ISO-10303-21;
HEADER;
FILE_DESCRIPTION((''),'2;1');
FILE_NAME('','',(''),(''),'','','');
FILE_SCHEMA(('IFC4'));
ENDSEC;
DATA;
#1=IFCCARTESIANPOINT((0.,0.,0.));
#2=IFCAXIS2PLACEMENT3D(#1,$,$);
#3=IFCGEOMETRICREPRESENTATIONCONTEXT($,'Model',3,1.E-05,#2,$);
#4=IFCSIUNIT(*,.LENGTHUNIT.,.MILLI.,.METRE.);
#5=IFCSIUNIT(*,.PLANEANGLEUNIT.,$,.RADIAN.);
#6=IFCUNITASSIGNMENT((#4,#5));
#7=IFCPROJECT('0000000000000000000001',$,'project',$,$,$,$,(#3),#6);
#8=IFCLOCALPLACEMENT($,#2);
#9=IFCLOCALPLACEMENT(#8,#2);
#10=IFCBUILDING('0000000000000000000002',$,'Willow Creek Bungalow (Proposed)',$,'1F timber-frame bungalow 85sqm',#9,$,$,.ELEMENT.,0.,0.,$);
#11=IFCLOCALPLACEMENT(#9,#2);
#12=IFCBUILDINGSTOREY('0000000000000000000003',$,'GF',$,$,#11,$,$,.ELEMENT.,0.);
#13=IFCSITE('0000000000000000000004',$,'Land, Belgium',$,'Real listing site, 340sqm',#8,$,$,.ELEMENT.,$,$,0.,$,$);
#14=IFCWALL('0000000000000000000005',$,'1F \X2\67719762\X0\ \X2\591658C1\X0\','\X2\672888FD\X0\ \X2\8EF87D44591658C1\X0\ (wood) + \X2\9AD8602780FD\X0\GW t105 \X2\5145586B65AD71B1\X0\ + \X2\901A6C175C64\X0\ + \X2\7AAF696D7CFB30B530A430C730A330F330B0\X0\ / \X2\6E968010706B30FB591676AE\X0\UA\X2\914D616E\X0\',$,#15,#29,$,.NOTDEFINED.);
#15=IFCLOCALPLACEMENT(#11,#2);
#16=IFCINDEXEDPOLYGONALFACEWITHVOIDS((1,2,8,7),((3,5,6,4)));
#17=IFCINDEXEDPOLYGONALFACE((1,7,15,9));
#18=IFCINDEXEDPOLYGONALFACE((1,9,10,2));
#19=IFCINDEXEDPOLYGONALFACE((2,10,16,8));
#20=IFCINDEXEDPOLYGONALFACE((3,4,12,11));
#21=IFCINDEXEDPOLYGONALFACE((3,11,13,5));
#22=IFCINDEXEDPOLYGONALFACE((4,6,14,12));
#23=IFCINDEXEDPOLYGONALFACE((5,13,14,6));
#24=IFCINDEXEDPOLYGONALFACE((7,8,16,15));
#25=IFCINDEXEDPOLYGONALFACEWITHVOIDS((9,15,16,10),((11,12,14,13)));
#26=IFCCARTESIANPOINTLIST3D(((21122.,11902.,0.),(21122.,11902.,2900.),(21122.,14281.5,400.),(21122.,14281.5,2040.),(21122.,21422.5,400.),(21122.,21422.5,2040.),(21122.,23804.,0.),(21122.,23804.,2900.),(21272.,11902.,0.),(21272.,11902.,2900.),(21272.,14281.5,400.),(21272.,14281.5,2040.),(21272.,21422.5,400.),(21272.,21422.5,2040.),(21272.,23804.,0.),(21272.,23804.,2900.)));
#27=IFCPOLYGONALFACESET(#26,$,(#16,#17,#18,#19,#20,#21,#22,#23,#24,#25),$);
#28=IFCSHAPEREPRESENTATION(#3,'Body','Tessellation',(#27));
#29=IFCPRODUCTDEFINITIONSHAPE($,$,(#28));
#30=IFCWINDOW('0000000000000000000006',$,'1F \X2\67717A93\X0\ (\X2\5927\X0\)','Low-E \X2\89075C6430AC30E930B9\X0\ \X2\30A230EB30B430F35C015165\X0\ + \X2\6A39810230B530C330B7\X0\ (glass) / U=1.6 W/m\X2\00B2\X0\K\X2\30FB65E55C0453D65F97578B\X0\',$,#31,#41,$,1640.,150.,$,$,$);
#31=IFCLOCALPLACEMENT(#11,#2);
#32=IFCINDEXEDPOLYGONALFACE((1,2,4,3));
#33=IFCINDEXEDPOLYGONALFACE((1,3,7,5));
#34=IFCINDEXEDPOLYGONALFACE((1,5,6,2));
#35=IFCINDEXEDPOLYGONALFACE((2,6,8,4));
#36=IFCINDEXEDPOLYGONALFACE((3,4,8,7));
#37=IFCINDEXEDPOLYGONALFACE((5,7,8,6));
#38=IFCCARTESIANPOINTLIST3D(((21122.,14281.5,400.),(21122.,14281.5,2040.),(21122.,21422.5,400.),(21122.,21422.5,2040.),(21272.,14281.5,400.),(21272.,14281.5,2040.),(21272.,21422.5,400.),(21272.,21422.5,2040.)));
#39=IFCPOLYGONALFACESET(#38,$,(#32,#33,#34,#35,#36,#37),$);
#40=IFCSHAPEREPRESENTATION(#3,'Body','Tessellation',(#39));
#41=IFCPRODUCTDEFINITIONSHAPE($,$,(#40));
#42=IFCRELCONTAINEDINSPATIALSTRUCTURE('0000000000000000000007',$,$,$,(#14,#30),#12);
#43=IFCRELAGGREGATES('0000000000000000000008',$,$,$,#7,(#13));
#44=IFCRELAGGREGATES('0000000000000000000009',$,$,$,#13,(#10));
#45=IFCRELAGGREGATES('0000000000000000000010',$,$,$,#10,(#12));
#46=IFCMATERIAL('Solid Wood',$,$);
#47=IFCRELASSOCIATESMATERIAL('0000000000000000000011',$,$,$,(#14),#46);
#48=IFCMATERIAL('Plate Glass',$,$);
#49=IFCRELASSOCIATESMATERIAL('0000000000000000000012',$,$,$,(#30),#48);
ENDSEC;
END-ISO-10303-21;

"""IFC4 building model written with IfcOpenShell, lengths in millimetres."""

from ifc_helpers import new_model, si_unit, frame, frame_2d, origin, place, context, project, spatial, rectangle, extrude, material, element, fill, save


model = new_model("IFC4")

# Units and contexts
model_context = context("Model", 3, precision=1e-05, world=origin())
ifc_project = project(units=[si_unit("LENGTHUNIT", "METRE", prefix="MILLI"), si_unit("PLANEANGLEUNIT", "RADIAN")], contexts=[model_context])

# Site, building, storey
site_placement = place(None, origin())
site = spatial("IfcSite", under=ifc_project, at=site_placement, Name="Land, Belgium", ObjectType="Real listing site, 340sqm", CompositionType="ELEMENT", RefElevation=0.0)
building_placement = place(site_placement, origin())
building = spatial("IfcBuilding", under=site, at=building_placement, Name="Willow Creek Bungalow (Proposed)", ObjectType="1F timber-frame bungalow 85sqm", CompositionType="ELEMENT", ElevationOfRefHeight=0.0, ElevationOfTerrain=0.0)
storey_placement = place(building_placement, origin())
storey = spatial("IfcBuildingStorey", under=building, at=storey_placement, Name="GF", CompositionType="ELEMENT", Elevation=0.0)

# Shared definitions
ifc_material_1 = material(Name="Solid Wood")

# Shared definitions
ifc_material_2 = material(Name="Plate Glass")

# Wall, opening, window
wall_1_placement = place(storey_placement, frame((10561.0, 5951.0, 0.0)))
wall_1 = element("IfcWall", 1, at=wall_1_placement, inside=storey, material=ifc_material_1, Name="1F 東面 外壁", Description="木製 軸組外壁 (wood) + 高性能GW t105 充填断熱 + 通気層 + 窯業系サイディング / 準耐火・外皮UA配慮", PredefinedType="NOTDEFINED", context=model_context, shape_type="SweptSolid", body=[
    extrude(rectangle(XDim=150.0, YDim=11902.0, at=frame_2d((75.0, 5951.0))), frame((10561.0, 5951.0, 0.0)), (0.0, 0.0, 1.0), 2900.0),
])
opening_1_placement = place(storey_placement, frame((10561.0, 7141.0, 200.0)))
opening_1 = element("IfcOpeningElement", 2, at=opening_1_placement, cuts=wall_1, PredefinedType="NOTDEFINED", context=model_context, shape_type="SweptSolid", body=[
    extrude(rectangle(XDim=150.0, YDim=7141.0, at=frame_2d((75.0, 3570.0))), frame((10561.0, 7141.0, 200.0)), (0.0, 0.0, 1.0), 1640.0),
])
window_1_placement = place(storey_placement, frame((10561.0, 7141.0, 200.0)))
window_1 = element("IfcWindow", 3, at=window_1_placement, inside=storey, material=ifc_material_2, Name="1F 東窓 (大)", Description="Low-E 複層ガラス アルゴン封入 + 樹脂サッシ (glass) / U=1.6 W/m²K・日射取得型", OverallHeight=1640.0, OverallWidth=150.0, context=model_context, shape_type="SweptSolid", body=[
    extrude(rectangle(XDim=150.0, YDim=7141.0, at=frame_2d((75.0, 3570.0))), frame((10561.0, 7141.0, 200.0)), (0.0, 0.0, 1.0), 1640.0),
])
fill(opening_1, window_1)

save(model, "model.ifc")
